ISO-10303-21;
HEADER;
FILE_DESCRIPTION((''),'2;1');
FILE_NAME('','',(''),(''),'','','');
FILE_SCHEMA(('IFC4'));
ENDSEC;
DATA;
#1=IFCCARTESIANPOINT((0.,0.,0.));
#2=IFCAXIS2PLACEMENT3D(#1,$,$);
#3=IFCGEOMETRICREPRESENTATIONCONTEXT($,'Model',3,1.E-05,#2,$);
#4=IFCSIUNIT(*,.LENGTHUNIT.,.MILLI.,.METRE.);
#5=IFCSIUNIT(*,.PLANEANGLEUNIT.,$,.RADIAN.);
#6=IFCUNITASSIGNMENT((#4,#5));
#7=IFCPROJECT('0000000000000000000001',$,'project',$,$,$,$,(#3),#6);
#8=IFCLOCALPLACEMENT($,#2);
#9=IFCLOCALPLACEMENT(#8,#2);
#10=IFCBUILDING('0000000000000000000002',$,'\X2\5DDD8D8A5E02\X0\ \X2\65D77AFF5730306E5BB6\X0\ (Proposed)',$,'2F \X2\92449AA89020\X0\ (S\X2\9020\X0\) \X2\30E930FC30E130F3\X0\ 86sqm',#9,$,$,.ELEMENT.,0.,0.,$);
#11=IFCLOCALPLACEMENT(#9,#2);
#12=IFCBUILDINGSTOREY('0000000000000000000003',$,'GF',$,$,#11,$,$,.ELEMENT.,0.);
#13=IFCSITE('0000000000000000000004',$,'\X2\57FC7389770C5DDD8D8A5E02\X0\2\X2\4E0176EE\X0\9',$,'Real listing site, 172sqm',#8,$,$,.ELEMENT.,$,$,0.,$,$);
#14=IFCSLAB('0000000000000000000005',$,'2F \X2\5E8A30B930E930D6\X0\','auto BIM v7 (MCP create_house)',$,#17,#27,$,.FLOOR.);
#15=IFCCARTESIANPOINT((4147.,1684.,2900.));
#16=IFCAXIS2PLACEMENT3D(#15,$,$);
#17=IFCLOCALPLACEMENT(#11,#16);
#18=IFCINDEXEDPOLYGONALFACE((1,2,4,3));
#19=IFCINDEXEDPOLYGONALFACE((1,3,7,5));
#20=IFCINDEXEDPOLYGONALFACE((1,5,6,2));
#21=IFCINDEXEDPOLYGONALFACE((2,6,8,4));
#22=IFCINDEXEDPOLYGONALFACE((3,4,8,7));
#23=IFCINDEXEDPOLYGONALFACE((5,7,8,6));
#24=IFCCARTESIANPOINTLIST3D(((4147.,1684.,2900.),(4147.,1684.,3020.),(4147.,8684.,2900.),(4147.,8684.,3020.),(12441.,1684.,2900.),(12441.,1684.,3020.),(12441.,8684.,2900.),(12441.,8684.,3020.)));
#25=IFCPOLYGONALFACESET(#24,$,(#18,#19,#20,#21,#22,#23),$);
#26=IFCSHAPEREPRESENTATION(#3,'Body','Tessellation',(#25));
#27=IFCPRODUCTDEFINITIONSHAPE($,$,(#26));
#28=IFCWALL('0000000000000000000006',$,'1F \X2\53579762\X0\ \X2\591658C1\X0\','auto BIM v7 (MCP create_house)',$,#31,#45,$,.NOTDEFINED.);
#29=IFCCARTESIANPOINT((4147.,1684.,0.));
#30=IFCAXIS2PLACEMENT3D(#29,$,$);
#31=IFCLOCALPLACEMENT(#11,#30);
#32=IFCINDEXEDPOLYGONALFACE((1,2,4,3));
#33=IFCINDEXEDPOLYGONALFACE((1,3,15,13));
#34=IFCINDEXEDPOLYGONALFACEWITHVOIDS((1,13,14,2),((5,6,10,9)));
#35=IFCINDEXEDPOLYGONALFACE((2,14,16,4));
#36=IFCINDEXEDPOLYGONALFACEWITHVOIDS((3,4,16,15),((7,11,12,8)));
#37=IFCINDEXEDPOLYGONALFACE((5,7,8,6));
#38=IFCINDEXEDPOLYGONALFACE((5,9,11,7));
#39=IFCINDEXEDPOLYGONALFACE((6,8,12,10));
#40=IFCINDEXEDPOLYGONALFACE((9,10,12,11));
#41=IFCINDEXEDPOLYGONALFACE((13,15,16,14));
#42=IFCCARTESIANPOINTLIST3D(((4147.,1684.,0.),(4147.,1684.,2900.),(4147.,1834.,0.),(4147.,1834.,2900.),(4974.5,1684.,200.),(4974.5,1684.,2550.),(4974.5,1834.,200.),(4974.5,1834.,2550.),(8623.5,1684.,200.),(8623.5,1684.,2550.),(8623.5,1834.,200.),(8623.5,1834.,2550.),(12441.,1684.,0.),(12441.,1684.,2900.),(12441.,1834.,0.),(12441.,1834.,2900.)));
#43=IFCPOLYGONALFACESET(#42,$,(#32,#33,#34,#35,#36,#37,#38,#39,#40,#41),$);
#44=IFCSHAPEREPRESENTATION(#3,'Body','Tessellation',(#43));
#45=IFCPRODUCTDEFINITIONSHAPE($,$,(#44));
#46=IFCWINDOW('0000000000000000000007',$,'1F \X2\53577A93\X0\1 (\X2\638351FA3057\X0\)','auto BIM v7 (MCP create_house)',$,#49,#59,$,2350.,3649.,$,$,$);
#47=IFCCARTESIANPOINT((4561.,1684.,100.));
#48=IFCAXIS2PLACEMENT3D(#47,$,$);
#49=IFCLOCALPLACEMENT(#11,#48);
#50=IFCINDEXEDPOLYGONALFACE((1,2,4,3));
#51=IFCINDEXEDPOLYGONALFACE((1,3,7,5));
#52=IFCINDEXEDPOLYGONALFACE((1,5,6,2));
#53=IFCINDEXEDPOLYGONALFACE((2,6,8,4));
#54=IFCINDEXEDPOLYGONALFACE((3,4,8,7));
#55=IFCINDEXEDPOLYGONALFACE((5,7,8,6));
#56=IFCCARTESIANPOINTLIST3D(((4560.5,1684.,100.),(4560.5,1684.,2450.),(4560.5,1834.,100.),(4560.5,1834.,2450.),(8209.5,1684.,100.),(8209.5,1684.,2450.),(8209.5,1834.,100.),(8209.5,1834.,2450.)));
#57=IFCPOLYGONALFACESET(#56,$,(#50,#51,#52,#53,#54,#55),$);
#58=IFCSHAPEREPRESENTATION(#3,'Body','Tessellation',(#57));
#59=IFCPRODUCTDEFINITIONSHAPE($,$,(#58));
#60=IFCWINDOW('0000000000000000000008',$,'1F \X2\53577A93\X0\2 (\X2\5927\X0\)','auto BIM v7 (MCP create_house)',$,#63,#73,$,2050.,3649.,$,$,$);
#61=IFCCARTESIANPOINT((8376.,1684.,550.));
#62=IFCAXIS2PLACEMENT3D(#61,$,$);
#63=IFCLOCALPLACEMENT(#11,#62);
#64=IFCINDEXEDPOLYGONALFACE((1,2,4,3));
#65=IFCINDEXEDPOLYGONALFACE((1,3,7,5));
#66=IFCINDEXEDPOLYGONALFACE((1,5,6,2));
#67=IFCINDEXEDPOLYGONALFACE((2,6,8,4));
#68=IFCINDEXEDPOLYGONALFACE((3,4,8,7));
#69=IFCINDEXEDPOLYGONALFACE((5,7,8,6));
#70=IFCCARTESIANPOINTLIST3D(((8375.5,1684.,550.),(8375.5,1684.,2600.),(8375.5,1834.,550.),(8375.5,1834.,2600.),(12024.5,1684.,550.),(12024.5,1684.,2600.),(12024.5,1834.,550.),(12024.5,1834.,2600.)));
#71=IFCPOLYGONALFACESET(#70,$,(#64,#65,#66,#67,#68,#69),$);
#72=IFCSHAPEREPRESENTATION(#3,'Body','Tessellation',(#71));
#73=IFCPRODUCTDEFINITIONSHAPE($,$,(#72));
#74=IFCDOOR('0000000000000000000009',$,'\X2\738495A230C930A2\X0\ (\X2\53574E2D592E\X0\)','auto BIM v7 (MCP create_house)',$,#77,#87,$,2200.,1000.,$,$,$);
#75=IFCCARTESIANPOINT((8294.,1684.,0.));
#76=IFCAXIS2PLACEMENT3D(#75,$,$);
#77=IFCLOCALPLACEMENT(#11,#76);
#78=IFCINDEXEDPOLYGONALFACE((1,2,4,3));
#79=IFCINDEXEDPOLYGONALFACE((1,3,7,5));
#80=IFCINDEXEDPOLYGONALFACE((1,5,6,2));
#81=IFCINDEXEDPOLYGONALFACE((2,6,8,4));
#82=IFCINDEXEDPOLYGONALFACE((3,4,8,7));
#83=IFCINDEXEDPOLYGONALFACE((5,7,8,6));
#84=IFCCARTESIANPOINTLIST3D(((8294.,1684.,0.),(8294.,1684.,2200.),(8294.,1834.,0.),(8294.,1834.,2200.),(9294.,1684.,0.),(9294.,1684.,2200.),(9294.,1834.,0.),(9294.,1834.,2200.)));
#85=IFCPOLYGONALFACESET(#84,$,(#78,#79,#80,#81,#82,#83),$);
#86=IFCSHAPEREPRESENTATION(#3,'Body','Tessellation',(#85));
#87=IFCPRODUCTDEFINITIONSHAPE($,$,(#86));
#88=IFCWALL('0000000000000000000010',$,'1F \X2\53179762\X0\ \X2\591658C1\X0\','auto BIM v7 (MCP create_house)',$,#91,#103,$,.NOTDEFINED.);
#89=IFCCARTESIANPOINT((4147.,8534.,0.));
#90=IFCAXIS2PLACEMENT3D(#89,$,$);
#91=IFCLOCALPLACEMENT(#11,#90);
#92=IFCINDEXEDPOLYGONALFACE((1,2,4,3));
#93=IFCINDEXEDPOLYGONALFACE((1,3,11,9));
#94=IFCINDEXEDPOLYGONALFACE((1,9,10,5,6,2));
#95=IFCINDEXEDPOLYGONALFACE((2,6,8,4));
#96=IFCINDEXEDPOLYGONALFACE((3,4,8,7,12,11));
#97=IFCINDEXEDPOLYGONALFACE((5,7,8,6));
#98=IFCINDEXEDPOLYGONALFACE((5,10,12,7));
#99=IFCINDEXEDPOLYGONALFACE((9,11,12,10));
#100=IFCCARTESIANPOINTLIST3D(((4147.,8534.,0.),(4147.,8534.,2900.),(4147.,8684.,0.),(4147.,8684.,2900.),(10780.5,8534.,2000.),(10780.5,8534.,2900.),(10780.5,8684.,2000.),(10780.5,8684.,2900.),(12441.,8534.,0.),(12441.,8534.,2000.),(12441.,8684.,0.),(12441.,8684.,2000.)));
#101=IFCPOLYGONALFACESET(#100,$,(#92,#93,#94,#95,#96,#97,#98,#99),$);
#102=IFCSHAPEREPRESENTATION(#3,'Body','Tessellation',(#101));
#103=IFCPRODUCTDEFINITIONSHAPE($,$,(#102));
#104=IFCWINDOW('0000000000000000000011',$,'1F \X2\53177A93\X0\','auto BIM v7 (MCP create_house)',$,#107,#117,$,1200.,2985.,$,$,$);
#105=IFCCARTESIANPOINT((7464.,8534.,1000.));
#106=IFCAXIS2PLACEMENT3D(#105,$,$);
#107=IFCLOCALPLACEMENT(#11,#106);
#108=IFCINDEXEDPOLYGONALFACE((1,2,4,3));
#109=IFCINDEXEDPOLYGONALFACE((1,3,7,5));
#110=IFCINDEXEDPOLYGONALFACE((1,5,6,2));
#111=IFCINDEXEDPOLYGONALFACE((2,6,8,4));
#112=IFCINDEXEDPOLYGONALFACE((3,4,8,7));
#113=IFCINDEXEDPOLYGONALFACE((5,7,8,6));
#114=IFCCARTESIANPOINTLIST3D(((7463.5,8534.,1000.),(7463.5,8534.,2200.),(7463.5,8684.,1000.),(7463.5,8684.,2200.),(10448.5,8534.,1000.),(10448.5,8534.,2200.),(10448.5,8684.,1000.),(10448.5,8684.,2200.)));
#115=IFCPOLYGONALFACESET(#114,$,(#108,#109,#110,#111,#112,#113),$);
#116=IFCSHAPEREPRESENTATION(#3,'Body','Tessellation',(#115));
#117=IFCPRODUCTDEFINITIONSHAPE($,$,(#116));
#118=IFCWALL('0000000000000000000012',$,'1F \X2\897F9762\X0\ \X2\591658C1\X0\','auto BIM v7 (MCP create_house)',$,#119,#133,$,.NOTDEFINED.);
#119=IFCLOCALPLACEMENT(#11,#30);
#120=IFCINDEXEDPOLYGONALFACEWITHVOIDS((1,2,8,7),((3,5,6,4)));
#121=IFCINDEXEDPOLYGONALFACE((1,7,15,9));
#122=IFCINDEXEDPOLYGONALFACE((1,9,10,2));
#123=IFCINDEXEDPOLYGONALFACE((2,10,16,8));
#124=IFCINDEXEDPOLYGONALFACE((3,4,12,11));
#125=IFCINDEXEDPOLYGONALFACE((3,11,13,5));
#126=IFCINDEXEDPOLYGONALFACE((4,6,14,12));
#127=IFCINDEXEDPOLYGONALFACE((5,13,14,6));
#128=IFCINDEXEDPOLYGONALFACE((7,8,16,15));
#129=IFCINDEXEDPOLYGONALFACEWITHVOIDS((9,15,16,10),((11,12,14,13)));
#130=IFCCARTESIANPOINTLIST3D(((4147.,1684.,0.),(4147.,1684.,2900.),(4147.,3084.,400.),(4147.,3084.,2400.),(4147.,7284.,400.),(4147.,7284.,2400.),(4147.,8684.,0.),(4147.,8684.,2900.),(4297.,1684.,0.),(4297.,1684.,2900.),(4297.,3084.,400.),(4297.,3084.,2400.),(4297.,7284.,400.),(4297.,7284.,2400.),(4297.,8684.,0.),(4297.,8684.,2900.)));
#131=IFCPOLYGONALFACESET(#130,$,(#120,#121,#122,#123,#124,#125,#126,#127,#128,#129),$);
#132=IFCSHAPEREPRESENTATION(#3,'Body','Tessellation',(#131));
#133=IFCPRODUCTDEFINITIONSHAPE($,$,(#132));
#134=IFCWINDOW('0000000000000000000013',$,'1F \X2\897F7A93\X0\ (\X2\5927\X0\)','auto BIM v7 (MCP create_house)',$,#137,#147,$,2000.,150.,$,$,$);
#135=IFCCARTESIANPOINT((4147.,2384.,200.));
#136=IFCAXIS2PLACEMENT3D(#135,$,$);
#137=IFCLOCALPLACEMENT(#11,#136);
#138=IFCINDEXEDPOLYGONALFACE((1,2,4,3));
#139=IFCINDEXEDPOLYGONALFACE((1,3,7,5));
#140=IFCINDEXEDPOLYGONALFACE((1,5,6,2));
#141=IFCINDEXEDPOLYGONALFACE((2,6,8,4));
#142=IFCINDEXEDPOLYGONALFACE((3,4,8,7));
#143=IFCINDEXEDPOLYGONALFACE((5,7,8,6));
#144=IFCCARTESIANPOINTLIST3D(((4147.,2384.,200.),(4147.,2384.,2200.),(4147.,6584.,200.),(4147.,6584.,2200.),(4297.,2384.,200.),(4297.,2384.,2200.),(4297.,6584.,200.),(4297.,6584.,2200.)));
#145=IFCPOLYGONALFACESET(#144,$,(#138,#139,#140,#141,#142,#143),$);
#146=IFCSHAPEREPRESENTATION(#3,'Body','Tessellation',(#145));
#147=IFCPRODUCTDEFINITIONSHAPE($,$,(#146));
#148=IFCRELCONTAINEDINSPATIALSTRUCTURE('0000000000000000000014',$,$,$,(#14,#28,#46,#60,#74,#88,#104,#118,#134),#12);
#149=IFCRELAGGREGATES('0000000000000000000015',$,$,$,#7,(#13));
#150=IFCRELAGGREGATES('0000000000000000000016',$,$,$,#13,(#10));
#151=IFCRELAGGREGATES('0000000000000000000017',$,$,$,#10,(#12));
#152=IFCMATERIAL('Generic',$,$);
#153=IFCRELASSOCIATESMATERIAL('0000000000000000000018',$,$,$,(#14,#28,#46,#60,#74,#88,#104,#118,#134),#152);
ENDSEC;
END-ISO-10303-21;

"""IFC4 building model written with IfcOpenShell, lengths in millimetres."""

from ifc_helpers import new_model, si_unit, frame, frame_2d, origin, place, context, project, spatial, rectangle, extrude, material, element, fill, save


model = new_model("IFC4")

# Units and contexts
model_context = context("Model", 3, precision=1e-05, world=origin())
ifc_project = project(units=[si_unit("LENGTHUNIT", "METRE", prefix="MILLI"), si_unit("PLANEANGLEUNIT", "RADIAN")], contexts=[model_context])

# Site, building, storey
site_placement = place(None, origin())
site = spatial("IfcSite", under=ifc_project, at=site_placement, Name="埼玉県川越市2丁目9", ObjectType="Real listing site, 172sqm", CompositionType="ELEMENT", RefElevation=0.0)
building_placement = place(site_placement, origin())
building = spatial("IfcBuilding", under=site, at=building_placement, Name="川越市 旗竿地の家 (Proposed)", ObjectType="2F 鉄骨造 (S造) ラーメン 86sqm", CompositionType="ELEMENT", ElevationOfRefHeight=0.0, ElevationOfTerrain=0.0)
storey_placement = place(building_placement, origin())
storey = spatial("IfcBuildingStorey", under=building, at=storey_placement, Name="GF", CompositionType="ELEMENT", Elevation=0.0)

# Slab
ifc_material = material(Name="Generic")
slab_1_placement = place(storey_placement, frame((4147.0, 1684.0, 2900.0)))
element("IfcSlab", 1, at=slab_1_placement, inside=storey, material=ifc_material, Name="2F 床スラブ", Description="auto BIM v7 (MCP create_house)", PredefinedType="FLOOR", context=model_context, shape_type="SweptSolid", body=[
    extrude(rectangle(XDim=8294.0, YDim=7000.0, at=frame_2d((4147.0, 3500.0))), frame((4147.0, 1684.0, 2900.0)), (0.0, 0.0, 1.0), 120.0),
])

# Wall, openings, windows, door
wall_1_placement = place(storey_placement, frame((4147.0, 1684.0, 0.0)))
wall_1 = element("IfcWall", 2, at=wall_1_placement, inside=storey, material=ifc_material, Name="1F 南面 外壁", Description="auto BIM v7 (MCP create_house)", PredefinedType="NOTDEFINED", context=model_context, shape_type="SweptSolid", body=[
    extrude(rectangle(XDim=8294.0, YDim=150.0, at=frame_2d((4147.0, 75.0))), frame((4147.0, 1684.0, 0.0)), (0.0, 0.0, 1.0), 2900.0),
])
opening_1_placement = place(storey_placement, frame((4561.0, 1684.0, 100.0)))
opening_1 = element("IfcOpeningElement", 3, at=opening_1_placement, cuts=wall_1, PredefinedType="NOTDEFINED", context=model_context, shape_type="SweptSolid", body=[
    extrude(rectangle(XDim=3649.0, YDim=150.0, at=frame_2d((1824.0, 75.0))), frame((4561.0, 1684.0, 100.0)), (0.0, 0.0, 1.0), 2350.0),
])
opening_2_placement = place(storey_placement, frame((8376.0, 1684.0, 550.0)))
opening_2 = element("IfcOpeningElement", 4, at=opening_2_placement, cuts=wall_1, PredefinedType="NOTDEFINED", context=model_context, shape_type="SweptSolid", body=[
    extrude(rectangle(XDim=3649.0, YDim=150.0, at=frame_2d((1824.0, 75.0))), frame((8376.0, 1684.0, 550.0)), (0.0, 0.0, 1.0), 2050.0),
])
opening_3_placement = place(storey_placement, frame((8294.0, 1684.0, 0.0)))
opening_3 = element("IfcOpeningElement", 5, at=opening_3_placement, cuts=wall_1, PredefinedType="NOTDEFINED", context=model_context, shape_type="SweptSolid", body=[
    extrude(rectangle(XDim=1000.0, YDim=150.0, at=frame_2d((500.0, 75.0))), frame((8294.0, 1684.0, 0.0)), (0.0, 0.0, 1.0), 2200.0),
])
window_1_placement = place(storey_placement, frame((4561.0, 1684.0, 100.0)))
window_1 = element("IfcWindow", 6, at=window_1_placement, inside=storey, material=ifc_material, Name="1F 南窓1 (掃出し)", Description="auto BIM v7 (MCP create_house)", OverallHeight=2350.0, OverallWidth=3649.0, context=model_context, shape_type="SweptSolid", body=[
    extrude(rectangle(XDim=3649.0, YDim=150.0, at=frame_2d((1824.0, 75.0))), frame((4561.0, 1684.0, 100.0)), (0.0, 0.0, 1.0), 2350.0),
])
fill(opening_1, window_1)
window_2_placement = place(storey_placement, frame((8376.0, 1684.0, 550.0)))
window_2 = element("IfcWindow", 7, at=window_2_placement, inside=storey, material=ifc_material, Name="1F 南窓2 (大)", Description="auto BIM v7 (MCP create_house)", OverallHeight=2050.0, OverallWidth=3649.0, context=model_context, shape_type="SweptSolid", body=[
    extrude(rectangle(XDim=3649.0, YDim=150.0, at=frame_2d((1824.0, 75.0))), frame((8376.0, 1684.0, 550.0)), (0.0, 0.0, 1.0), 2050.0),
])
fill(opening_2, window_2)
door_placement = place(storey_placement, frame((8294.0, 1684.0, 0.0)))
door = element("IfcDoor", 8, at=door_placement, inside=storey, material=ifc_material, Name="玄関ドア (南中央)", Description="auto BIM v7 (MCP create_house)", OverallHeight=2200.0, OverallWidth=1000.0, context=model_context, shape_type="SweptSolid", body=[
    extrude(rectangle(XDim=1000.0, YDim=150.0, at=frame_2d((500.0, 75.0))), frame((8294.0, 1684.0, 0.0)), (0.0, 0.0, 1.0), 2200.0),
])
fill(opening_3, door)

# Walls, openings, windows
wall_2_placement = place(storey_placement, frame((4147.0, 8534.0, 0.0)))
wall_2 = element("IfcWall", 9, at=wall_2_placement, inside=storey, material=ifc_material, Name="1F 北面 外壁", Description="auto BIM v7 (MCP create_house)", PredefinedType="NOTDEFINED", context=model_context, shape_type="SweptSolid", body=[
    extrude(rectangle(XDim=8294.0, YDim=150.0, at=frame_2d((4147.0, 75.0))), frame((4147.0, 8534.0, 0.0)), (0.0, 0.0, 1.0), 2900.0),
])
opening_4_placement = place(storey_placement, frame((7464.0, 8534.0, 1000.0)))
opening_4 = element("IfcOpeningElement", 10, at=opening_4_placement, cuts=wall_2, PredefinedType="NOTDEFINED", context=model_context, shape_type="SweptSolid", body=[
    extrude(rectangle(XDim=2985.0, YDim=150.0, at=frame_2d((1492.0, 75.0))), frame((7464.0, 8534.0, 1000.0)), (0.0, 0.0, 1.0), 1200.0),
])
window_3_placement = place(storey_placement, frame((7464.0, 8534.0, 1000.0)))
window_3 = element("IfcWindow", 11, at=window_3_placement, inside=storey, material=ifc_material, Name="1F 北窓", Description="auto BIM v7 (MCP create_house)", OverallHeight=1200.0, OverallWidth=2985.0, context=model_context, shape_type="SweptSolid", body=[
    extrude(rectangle(XDim=2985.0, YDim=150.0, at=frame_2d((1492.0, 75.0))), frame((7464.0, 8534.0, 1000.0)), (0.0, 0.0, 1.0), 1200.0),
])
fill(opening_4, window_3)
wall_3_placement = place(storey_placement, frame((4147.0, 1684.0, 0.0)))
wall_3 = element("IfcWall", 12, at=wall_3_placement, inside=storey, material=ifc_material, Name="1F 西面 外壁", Description="auto BIM v7 (MCP create_house)", PredefinedType="NOTDEFINED", context=model_context, shape_type="SweptSolid", body=[
    extrude(rectangle(XDim=150.0, YDim=7000.0, at=frame_2d((75.0, 3500.0))), frame((4147.0, 1684.0, 0.0)), (0.0, 0.0, 1.0), 2900.0),
])
opening_5_placement = place(storey_placement, frame((4147.0, 2384.0, 200.0)))
opening_5 = element("IfcOpeningElement", 13, at=opening_5_placement, cuts=wall_3, PredefinedType="NOTDEFINED", context=model_context, shape_type="SweptSolid", body=[
    extrude(rectangle(XDim=150.0, YDim=4200.0, at=frame_2d((75.0, 2100.0))), frame((4147.0, 2384.0, 200.0)), (0.0, 0.0, 1.0), 2000.0),
])
window_4_placement = place(storey_placement, frame((4147.0, 2384.0, 200.0)))
window_4 = element("IfcWindow", 14, at=window_4_placement, inside=storey, material=ifc_material, Name="1F 西窓 (大)", Description="auto BIM v7 (MCP create_house)", OverallHeight=2000.0, OverallWidth=150.0, context=model_context, shape_type="SweptSolid", body=[
    extrude(rectangle(XDim=150.0, YDim=4200.0, at=frame_2d((75.0, 2100.0))), frame((4147.0, 2384.0, 200.0)), (0.0, 0.0, 1.0), 2000.0),
])
fill(opening_5, window_4)

save(model, "model.ifc")
